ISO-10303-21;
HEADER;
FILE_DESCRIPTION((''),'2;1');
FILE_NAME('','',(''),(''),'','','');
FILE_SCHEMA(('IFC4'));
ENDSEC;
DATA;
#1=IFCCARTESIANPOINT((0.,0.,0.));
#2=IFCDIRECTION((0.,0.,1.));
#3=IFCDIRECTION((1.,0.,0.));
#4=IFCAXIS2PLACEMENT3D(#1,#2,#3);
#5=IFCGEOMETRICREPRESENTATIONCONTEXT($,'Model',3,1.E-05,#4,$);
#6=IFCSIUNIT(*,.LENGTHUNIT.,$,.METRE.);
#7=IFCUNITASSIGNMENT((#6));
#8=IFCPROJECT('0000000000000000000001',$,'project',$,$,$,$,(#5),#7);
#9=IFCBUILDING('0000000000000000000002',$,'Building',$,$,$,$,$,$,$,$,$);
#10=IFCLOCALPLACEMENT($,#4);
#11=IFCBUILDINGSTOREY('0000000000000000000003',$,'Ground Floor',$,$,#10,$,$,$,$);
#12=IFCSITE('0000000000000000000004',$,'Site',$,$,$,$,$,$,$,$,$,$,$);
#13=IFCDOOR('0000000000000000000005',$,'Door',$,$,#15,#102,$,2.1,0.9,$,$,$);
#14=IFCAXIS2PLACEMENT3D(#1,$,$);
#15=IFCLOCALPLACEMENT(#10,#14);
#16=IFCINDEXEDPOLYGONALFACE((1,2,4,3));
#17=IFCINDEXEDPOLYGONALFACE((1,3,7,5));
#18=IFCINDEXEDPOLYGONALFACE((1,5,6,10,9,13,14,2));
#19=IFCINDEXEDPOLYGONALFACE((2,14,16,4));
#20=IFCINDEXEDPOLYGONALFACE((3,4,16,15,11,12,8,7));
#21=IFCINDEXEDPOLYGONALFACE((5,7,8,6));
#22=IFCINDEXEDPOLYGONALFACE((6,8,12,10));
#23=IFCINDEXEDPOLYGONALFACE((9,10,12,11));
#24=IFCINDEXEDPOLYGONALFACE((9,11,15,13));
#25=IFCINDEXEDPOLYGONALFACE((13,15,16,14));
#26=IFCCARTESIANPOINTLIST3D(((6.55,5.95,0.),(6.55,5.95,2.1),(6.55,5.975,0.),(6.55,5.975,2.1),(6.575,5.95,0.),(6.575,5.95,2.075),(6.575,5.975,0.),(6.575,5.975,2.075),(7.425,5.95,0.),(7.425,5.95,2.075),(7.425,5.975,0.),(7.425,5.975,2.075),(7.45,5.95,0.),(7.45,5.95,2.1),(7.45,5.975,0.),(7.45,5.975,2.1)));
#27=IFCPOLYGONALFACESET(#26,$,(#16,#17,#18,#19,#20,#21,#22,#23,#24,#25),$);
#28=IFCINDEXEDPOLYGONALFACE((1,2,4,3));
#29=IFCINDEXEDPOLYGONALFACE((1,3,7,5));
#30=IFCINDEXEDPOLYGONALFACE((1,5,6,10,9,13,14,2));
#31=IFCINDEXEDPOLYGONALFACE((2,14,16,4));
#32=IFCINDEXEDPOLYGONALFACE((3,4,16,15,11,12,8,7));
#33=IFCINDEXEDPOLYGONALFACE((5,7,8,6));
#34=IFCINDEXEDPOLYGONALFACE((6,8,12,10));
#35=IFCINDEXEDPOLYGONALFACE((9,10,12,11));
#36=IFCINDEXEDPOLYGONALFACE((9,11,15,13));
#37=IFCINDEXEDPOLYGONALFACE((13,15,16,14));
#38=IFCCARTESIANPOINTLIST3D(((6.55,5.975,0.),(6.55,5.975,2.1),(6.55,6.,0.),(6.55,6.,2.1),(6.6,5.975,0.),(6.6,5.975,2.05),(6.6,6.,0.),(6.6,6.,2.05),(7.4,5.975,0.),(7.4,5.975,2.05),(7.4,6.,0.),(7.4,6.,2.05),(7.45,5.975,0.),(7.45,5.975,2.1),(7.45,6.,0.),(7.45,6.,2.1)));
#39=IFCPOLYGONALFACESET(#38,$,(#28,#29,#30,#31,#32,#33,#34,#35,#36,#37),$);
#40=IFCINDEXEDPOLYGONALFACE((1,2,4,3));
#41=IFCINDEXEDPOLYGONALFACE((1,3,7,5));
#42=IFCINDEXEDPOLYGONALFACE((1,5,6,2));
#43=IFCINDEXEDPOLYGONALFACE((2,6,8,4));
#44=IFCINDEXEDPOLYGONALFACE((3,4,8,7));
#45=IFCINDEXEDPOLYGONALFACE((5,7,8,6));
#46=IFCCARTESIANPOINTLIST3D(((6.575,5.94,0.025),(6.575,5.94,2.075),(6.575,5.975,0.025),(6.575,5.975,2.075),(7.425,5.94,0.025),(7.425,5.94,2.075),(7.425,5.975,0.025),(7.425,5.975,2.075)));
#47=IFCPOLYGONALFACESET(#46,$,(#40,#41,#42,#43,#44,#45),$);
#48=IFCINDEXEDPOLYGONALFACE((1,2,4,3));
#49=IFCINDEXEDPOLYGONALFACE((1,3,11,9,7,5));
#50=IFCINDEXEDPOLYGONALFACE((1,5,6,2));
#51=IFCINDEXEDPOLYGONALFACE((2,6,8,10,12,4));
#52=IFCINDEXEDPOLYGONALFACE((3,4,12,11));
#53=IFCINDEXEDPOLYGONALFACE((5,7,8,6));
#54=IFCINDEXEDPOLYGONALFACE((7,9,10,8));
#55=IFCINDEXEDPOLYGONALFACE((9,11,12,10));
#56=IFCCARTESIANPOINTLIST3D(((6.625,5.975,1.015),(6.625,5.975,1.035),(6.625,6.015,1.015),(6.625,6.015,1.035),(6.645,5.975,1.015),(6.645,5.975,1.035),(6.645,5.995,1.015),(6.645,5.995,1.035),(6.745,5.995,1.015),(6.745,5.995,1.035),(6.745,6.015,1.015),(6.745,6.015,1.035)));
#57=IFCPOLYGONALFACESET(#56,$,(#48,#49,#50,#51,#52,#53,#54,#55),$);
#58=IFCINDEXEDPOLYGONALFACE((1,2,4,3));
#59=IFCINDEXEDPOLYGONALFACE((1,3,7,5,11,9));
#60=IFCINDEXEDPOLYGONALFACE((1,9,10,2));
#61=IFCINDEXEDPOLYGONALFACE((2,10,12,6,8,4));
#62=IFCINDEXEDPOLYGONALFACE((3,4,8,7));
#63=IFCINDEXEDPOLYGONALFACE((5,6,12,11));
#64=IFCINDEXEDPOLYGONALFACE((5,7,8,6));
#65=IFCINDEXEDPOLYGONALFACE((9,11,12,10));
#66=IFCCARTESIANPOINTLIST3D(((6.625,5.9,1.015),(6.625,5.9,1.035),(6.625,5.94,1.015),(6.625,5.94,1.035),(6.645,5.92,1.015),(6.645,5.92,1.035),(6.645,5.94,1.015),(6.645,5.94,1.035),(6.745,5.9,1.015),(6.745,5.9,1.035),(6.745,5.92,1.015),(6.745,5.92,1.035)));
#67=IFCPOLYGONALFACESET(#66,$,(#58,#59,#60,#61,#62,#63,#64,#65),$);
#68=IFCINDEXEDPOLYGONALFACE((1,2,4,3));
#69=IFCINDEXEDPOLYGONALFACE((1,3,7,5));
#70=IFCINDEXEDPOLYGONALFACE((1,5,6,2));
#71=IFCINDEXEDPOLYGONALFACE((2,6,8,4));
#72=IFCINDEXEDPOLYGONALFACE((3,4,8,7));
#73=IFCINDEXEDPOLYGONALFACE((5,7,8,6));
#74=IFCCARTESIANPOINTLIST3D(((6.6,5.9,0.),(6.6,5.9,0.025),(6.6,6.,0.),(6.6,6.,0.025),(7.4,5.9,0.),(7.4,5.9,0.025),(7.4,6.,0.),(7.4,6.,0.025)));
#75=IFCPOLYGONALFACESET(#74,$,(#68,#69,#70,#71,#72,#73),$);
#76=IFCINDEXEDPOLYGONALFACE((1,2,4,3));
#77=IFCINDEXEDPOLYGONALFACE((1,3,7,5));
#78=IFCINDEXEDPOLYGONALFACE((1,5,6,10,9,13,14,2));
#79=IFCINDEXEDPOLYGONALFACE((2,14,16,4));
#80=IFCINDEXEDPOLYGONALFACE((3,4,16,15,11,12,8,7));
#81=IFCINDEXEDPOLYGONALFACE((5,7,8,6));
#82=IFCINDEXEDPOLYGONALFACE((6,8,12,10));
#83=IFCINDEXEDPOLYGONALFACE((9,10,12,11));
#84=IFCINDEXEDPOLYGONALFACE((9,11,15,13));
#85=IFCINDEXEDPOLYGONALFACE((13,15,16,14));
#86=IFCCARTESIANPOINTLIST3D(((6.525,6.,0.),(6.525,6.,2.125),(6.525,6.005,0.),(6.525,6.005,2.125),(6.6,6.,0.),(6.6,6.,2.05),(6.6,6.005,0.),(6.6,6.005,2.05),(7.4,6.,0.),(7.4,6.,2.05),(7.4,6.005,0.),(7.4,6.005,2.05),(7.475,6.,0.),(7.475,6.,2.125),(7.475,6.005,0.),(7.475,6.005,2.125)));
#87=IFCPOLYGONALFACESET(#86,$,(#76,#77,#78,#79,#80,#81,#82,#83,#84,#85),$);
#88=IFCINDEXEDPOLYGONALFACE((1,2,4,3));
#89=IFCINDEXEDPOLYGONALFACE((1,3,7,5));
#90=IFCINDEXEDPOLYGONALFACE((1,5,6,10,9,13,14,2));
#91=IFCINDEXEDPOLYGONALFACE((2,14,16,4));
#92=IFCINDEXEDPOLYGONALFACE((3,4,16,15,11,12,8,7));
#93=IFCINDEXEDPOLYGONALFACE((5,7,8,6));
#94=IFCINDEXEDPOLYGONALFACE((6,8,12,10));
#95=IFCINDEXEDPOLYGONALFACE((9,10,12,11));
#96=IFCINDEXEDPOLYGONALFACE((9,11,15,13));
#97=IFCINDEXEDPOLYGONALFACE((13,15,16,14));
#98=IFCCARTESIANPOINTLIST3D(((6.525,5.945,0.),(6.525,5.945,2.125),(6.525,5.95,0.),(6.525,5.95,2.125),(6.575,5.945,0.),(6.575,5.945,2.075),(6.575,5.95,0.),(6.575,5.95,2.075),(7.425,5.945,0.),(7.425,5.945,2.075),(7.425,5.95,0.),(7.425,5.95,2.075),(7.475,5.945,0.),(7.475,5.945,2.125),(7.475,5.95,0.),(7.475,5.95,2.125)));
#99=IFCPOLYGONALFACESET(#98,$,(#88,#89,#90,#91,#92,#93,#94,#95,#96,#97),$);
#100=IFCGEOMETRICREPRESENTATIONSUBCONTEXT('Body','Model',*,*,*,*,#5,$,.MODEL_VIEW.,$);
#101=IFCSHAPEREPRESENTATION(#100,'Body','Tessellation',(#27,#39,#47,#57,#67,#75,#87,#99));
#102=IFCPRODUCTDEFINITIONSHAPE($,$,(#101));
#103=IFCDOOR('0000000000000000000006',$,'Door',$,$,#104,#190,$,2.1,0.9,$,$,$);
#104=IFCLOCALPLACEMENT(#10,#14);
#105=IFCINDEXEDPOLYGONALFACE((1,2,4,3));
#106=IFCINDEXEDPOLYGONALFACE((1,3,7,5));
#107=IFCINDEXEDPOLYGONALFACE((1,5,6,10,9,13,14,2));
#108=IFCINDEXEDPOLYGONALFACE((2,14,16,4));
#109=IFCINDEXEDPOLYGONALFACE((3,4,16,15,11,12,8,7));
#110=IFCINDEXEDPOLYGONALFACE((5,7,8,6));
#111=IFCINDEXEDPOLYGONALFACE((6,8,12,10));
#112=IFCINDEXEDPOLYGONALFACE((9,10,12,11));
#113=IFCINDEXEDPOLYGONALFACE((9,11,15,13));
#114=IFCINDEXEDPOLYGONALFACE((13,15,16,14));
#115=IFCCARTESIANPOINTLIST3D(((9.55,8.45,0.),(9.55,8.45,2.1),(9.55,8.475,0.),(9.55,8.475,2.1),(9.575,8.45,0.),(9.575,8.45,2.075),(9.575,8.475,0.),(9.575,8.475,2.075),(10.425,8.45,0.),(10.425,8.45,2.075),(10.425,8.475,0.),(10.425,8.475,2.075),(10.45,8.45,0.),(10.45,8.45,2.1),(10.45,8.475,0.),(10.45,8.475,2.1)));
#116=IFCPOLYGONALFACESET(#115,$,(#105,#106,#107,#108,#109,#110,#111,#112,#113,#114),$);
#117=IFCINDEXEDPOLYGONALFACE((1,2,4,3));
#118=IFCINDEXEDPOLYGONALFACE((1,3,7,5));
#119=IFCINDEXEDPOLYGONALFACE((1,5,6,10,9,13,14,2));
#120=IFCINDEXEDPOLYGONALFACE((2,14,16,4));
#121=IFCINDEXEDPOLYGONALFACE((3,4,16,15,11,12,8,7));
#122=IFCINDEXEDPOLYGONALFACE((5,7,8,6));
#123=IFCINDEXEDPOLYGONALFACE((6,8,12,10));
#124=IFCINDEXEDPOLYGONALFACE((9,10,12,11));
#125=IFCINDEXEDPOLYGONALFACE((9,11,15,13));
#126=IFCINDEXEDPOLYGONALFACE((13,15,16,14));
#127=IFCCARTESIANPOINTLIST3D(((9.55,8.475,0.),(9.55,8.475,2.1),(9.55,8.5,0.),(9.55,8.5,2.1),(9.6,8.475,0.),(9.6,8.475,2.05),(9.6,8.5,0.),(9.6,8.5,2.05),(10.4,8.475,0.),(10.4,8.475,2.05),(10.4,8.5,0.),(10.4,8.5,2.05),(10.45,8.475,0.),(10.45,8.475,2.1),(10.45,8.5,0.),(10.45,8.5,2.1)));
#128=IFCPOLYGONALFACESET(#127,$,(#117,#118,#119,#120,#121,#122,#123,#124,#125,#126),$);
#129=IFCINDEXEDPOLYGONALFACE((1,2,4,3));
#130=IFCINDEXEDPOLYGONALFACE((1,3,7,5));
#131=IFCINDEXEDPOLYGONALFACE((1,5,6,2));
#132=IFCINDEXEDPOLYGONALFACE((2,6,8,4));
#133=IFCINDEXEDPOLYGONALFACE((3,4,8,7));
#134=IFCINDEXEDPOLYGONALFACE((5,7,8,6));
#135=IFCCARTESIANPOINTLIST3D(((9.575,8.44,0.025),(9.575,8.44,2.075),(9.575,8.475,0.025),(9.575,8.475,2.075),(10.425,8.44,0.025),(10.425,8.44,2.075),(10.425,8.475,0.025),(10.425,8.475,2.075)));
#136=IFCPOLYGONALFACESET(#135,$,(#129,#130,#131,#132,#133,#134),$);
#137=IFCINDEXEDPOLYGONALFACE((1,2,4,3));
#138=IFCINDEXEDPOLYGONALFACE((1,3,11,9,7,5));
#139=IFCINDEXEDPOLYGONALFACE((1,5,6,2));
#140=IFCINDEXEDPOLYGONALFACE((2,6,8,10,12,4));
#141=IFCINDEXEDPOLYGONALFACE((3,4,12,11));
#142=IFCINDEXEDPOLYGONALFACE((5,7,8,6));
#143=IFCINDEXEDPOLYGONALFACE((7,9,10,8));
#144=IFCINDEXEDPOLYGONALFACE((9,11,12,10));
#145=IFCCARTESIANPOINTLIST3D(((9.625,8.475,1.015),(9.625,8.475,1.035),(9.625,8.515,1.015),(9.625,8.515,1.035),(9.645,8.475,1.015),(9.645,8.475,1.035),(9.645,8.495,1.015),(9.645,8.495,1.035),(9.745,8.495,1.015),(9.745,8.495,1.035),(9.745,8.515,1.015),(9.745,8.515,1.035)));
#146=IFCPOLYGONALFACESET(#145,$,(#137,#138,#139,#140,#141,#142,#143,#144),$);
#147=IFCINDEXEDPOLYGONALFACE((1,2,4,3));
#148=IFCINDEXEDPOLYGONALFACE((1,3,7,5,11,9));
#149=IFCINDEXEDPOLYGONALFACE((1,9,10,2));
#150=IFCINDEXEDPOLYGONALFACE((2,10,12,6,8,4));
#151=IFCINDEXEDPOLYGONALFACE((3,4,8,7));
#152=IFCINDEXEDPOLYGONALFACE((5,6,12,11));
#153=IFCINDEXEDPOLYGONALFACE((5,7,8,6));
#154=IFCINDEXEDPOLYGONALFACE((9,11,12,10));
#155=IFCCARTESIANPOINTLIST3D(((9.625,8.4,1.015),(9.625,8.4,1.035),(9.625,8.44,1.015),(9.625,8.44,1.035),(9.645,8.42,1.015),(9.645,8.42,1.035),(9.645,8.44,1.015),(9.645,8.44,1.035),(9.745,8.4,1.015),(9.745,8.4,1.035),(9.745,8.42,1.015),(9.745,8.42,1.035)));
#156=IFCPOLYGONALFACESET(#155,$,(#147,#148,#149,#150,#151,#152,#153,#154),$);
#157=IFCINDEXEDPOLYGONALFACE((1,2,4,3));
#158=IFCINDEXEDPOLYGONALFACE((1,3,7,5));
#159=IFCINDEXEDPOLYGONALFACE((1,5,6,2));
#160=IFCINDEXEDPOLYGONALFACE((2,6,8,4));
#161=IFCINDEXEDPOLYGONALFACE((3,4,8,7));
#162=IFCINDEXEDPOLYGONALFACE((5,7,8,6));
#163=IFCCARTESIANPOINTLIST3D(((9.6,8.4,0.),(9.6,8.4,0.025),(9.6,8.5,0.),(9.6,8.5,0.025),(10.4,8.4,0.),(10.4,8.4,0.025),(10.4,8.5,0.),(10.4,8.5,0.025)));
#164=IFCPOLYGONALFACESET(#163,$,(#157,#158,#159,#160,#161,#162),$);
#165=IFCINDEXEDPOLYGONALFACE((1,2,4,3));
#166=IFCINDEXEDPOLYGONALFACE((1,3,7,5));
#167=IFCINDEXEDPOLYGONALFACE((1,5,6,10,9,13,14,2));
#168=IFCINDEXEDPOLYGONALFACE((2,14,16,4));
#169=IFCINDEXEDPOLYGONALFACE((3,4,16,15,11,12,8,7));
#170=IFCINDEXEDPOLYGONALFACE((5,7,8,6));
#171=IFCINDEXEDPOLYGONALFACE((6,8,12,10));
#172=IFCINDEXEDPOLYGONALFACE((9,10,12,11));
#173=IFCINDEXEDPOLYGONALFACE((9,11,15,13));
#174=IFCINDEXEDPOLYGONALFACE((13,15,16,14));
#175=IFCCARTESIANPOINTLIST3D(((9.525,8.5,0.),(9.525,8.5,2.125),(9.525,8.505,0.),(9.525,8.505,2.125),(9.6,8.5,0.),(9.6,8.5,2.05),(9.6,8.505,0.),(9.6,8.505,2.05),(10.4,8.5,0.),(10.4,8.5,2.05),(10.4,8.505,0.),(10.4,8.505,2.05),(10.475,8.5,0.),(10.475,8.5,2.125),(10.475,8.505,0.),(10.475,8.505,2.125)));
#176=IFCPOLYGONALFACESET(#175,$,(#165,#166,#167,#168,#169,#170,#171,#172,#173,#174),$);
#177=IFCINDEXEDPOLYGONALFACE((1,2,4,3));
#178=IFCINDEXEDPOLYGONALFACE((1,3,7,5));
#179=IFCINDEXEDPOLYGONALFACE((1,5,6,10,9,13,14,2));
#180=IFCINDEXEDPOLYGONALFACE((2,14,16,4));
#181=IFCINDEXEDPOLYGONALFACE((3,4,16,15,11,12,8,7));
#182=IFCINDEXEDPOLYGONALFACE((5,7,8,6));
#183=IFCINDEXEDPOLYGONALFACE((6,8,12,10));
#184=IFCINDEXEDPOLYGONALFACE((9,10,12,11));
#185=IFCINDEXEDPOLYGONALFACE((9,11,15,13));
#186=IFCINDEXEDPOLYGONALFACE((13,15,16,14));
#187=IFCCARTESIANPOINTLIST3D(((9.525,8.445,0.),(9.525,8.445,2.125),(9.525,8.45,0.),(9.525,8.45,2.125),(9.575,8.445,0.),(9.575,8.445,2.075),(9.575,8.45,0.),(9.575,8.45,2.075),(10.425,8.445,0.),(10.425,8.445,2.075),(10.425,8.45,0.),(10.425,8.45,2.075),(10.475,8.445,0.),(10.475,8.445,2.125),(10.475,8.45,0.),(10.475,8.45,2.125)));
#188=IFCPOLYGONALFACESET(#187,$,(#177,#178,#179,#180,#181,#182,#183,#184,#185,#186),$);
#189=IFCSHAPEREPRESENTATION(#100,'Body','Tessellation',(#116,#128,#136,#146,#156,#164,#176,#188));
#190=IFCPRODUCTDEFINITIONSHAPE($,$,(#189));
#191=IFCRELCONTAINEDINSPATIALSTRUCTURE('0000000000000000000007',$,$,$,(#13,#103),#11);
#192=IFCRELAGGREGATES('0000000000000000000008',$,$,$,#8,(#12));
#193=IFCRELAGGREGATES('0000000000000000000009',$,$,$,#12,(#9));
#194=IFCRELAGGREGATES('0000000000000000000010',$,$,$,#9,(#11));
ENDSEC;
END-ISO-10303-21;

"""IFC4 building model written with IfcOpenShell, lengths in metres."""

from ifc_helpers import new_model, si_unit, frame, origin_with_axes, place, context, subcontext, project, spatial, line, indexed_curve, outline, extrude, element, save


model = new_model("IFC4")

# Units and contexts
model_context = context("Model", 3, precision=1e-05, world=origin_with_axes())
body_context = subcontext(model_context, "Body", "Model", "MODEL_VIEW")
ifc_project = project(units=[si_unit("LENGTHUNIT", "METRE")], contexts=[model_context])

# Site, building, storey
site = spatial("IfcSite", under=ifc_project, Name="Site")
building = spatial("IfcBuilding", under=site, Name="Building")
storey_placement = place(None, origin_with_axes())
storey = spatial("IfcBuildingStorey", under=building, at=storey_placement, Name="Ground Floor")

# Doors
door_1_placement = place(storey_placement, frame((7.45, 6.0, 0.0), z_axis=(0.0, 0.0, 1.0), x_axis=(-1.0, 0.0, 0.0)))
element("IfcDoor", 1, at=door_1_placement, inside=storey, Name="Door", OverallHeight=2.1, OverallWidth=0.9, context=body_context, shape_type="SweptSolid", body=[
    extrude(outline(indexed_curve([(0.0, 0.0), (0.0, 2.1), (0.9, 2.1), (0.9, 0.0), (0.875, 0.0), (0.875, 2.075), (0.025, 2.075), (0.025, 0.0)], segments=[line(1, 2, 3, 4, 5, 6, 7, 8, 1)])), frame((0.0, 0.025, 0.0), z_axis=(0.0, -1.0, 0.0), x_axis=(1.0, 0.0, 0.0)), (0.0, 0.0, -1.0), 0.025),
    extrude(outline(indexed_curve([(0.0, 0.0), (0.0, 2.1), (0.9, 2.1), (0.9, 0.0), (0.85, 0.0), (0.85, 2.05), (0.05, 2.05), (0.05, 0.0)], segments=[line(1, 2, 3, 4, 5, 6, 7, 8, 1)])), frame((0.0, 0.0, 0.0), z_axis=(0.0, -1.0, 0.0), x_axis=(1.0, 0.0, 0.0)), (0.0, 0.0, -1.0), 0.025),
    extrude(outline(indexed_curve([(0.0, 0.0), (0.85, 0.0), (0.85, 0.035), (0.0, 0.035)], segments=[line(1, 2, 3, 4, 1)])), frame((0.025, 0.025, 0.025), z_axis=(0.0, 0.0, 1.0), x_axis=(1.0, 0.0, 0.0)), (0.0, 0.0, 1.0), 2.05),
    extrude(outline(indexed_curve([(0.0, 0.0), (0.0, -0.04), (-0.12, -0.04), (-0.12, -0.02), (-0.02, -0.02), (-0.02, 0.0)], segments=[line(1, 2, 3, 4, 5, 6, 1)])), frame((0.825, 0.025, 1.015), z_axis=(0.0, 0.0, 1.0), x_axis=(1.0, 0.0, 0.0)), (0.0, 0.0, 1.0), 0.02),
    extrude(outline(indexed_curve([(0.0, 0.0), (0.0, 0.04), (-0.12, 0.04), (-0.12, 0.02), (-0.02, 0.02), (-0.02, 0.0)], segments=[line(1, 2, 3, 4, 5, 6, 1)])), frame((0.825, 0.06, 1.015), z_axis=(0.0, 0.0, 1.0), x_axis=(1.0, 0.0, 0.0)), (0.0, 0.0, 1.0), 0.02),
    extrude(outline(indexed_curve([(0.0, 0.0), (0.8, 0.0), (0.8, 0.1), (0.0, 0.1)], segments=[line(1, 2, 3, 4, 1)])), frame((0.05, 0.0, 0.0), z_axis=(0.0, 0.0, 1.0), x_axis=(1.0, 0.0, 0.0)), (0.0, 0.0, 1.0), 0.025),
    extrude(outline(indexed_curve([(0.0, 0.0), (0.0, 2.125), (0.95, 2.125), (0.95, 0.0), (0.875, 0.0), (0.875, 2.05), (0.075, 2.05), (0.075, 0.0)], segments=[line(1, 2, 3, 4, 5, 6, 7, 8, 1)])), frame((-0.025, -0.005, 0.0), z_axis=(0.0, -1.0, 0.0), x_axis=(1.0, 0.0, 0.0)), (0.0, 0.0, -1.0), 0.005),
    extrude(outline(indexed_curve([(0.0, 0.0), (0.0, 2.125), (0.95, 2.125), (0.95, 0.0), (0.9, 0.0), (0.9, 2.075), (0.05, 2.075), (0.05, 0.0)], segments=[line(1, 2, 3, 4, 5, 6, 7, 8, 1)])), frame((-0.025, 0.05, 0.0), z_axis=(0.0, -1.0, 0.0), x_axis=(1.0, 0.0, 0.0)), (0.0, 0.0, -1.0), 0.005),
])
door_2_placement = place(storey_placement, frame((10.45, 8.5, 0.0), z_axis=(0.0, 0.0, 1.0), x_axis=(-1.0, 0.0, 0.0)))
element("IfcDoor", 2, at=door_2_placement, inside=storey, Name="Door", OverallHeight=2.1, OverallWidth=0.9, context=body_context, shape_type="SweptSolid", body=[
    extrude(outline(indexed_curve([(0.0, 0.0), (0.0, 2.1), (0.9, 2.1), (0.9, 0.0), (0.875, 0.0), (0.875, 2.075), (0.025, 2.075), (0.025, 0.0)], segments=[line(1, 2, 3, 4, 5, 6, 7, 8, 1)])), frame((0.0, 0.025, 0.0), z_axis=(0.0, -1.0, 0.0), x_axis=(1.0, 0.0, 0.0)), (0.0, 0.0, -1.0), 0.025),
    extrude(outline(indexed_curve([(0.0, 0.0), (0.0, 2.1), (0.9, 2.1), (0.9, 0.0), (0.85, 0.0), (0.85, 2.05), (0.05, 2.05), (0.05, 0.0)], segments=[line(1, 2, 3, 4, 5, 6, 7, 8, 1)])), frame((0.0, 0.0, 0.0), z_axis=(0.0, -1.0, 0.0), x_axis=(1.0, 0.0, 0.0)), (0.0, 0.0, -1.0), 0.025),
    extrude(outline(indexed_curve([(0.0, 0.0), (0.85, 0.0), (0.85, 0.035), (0.0, 0.035)], segments=[line(1, 2, 3, 4, 1)])), frame((0.025, 0.025, 0.025), z_axis=(0.0, 0.0, 1.0), x_axis=(1.0, 0.0, 0.0)), (0.0, 0.0, 1.0), 2.05),
    extrude(outline(indexed_curve([(0.0, 0.0), (0.0, -0.04), (-0.12, -0.04), (-0.12, -0.02), (-0.02, -0.02), (-0.02, 0.0)], segments=[line(1, 2, 3, 4, 5, 6, 1)])), frame((0.825, 0.025, 1.015), z_axis=(0.0, 0.0, 1.0), x_axis=(1.0, 0.0, 0.0)), (0.0, 0.0, 1.0), 0.02),
    extrude(outline(indexed_curve([(0.0, 0.0), (0.0, 0.04), (-0.12, 0.04), (-0.12, 0.02), (-0.02, 0.02), (-0.02, 0.0)], segments=[line(1, 2, 3, 4, 5, 6, 1)])), frame((0.825, 0.06, 1.015), z_axis=(0.0, 0.0, 1.0), x_axis=(1.0, 0.0, 0.0)), (0.0, 0.0, 1.0), 0.02),
    extrude(outline(indexed_curve([(0.0, 0.0), (0.8, 0.0), (0.8, 0.1), (0.0, 0.1)], segments=[line(1, 2, 3, 4, 1)])), frame((0.05, 0.0, 0.0), z_axis=(0.0, 0.0, 1.0), x_axis=(1.0, 0.0, 0.0)), (0.0, 0.0, 1.0), 0.025),
    extrude(outline(indexed_curve([(0.0, 0.0), (0.0, 2.125), (0.95, 2.125), (0.95, 0.0), (0.875, 0.0), (0.875, 2.05), (0.075, 2.05), (0.075, 0.0)], segments=[line(1, 2, 3, 4, 5, 6, 7, 8, 1)])), frame((-0.025, -0.005, 0.0), z_axis=(0.0, -1.0, 0.0), x_axis=(1.0, 0.0, 0.0)), (0.0, 0.0, -1.0), 0.005),
    extrude(outline(indexed_curve([(0.0, 0.0), (0.0, 2.125), (0.95, 2.125), (0.95, 0.0), (0.9, 0.0), (0.9, 2.075), (0.05, 2.075), (0.05, 0.0)], segments=[line(1, 2, 3, 4, 5, 6, 7, 8, 1)])), frame((-0.025, 0.05, 0.0), z_axis=(0.0, -1.0, 0.0), x_axis=(1.0, 0.0, 0.0)), (0.0, 0.0, -1.0), 0.005),
])

save(model, "model.ifc")
